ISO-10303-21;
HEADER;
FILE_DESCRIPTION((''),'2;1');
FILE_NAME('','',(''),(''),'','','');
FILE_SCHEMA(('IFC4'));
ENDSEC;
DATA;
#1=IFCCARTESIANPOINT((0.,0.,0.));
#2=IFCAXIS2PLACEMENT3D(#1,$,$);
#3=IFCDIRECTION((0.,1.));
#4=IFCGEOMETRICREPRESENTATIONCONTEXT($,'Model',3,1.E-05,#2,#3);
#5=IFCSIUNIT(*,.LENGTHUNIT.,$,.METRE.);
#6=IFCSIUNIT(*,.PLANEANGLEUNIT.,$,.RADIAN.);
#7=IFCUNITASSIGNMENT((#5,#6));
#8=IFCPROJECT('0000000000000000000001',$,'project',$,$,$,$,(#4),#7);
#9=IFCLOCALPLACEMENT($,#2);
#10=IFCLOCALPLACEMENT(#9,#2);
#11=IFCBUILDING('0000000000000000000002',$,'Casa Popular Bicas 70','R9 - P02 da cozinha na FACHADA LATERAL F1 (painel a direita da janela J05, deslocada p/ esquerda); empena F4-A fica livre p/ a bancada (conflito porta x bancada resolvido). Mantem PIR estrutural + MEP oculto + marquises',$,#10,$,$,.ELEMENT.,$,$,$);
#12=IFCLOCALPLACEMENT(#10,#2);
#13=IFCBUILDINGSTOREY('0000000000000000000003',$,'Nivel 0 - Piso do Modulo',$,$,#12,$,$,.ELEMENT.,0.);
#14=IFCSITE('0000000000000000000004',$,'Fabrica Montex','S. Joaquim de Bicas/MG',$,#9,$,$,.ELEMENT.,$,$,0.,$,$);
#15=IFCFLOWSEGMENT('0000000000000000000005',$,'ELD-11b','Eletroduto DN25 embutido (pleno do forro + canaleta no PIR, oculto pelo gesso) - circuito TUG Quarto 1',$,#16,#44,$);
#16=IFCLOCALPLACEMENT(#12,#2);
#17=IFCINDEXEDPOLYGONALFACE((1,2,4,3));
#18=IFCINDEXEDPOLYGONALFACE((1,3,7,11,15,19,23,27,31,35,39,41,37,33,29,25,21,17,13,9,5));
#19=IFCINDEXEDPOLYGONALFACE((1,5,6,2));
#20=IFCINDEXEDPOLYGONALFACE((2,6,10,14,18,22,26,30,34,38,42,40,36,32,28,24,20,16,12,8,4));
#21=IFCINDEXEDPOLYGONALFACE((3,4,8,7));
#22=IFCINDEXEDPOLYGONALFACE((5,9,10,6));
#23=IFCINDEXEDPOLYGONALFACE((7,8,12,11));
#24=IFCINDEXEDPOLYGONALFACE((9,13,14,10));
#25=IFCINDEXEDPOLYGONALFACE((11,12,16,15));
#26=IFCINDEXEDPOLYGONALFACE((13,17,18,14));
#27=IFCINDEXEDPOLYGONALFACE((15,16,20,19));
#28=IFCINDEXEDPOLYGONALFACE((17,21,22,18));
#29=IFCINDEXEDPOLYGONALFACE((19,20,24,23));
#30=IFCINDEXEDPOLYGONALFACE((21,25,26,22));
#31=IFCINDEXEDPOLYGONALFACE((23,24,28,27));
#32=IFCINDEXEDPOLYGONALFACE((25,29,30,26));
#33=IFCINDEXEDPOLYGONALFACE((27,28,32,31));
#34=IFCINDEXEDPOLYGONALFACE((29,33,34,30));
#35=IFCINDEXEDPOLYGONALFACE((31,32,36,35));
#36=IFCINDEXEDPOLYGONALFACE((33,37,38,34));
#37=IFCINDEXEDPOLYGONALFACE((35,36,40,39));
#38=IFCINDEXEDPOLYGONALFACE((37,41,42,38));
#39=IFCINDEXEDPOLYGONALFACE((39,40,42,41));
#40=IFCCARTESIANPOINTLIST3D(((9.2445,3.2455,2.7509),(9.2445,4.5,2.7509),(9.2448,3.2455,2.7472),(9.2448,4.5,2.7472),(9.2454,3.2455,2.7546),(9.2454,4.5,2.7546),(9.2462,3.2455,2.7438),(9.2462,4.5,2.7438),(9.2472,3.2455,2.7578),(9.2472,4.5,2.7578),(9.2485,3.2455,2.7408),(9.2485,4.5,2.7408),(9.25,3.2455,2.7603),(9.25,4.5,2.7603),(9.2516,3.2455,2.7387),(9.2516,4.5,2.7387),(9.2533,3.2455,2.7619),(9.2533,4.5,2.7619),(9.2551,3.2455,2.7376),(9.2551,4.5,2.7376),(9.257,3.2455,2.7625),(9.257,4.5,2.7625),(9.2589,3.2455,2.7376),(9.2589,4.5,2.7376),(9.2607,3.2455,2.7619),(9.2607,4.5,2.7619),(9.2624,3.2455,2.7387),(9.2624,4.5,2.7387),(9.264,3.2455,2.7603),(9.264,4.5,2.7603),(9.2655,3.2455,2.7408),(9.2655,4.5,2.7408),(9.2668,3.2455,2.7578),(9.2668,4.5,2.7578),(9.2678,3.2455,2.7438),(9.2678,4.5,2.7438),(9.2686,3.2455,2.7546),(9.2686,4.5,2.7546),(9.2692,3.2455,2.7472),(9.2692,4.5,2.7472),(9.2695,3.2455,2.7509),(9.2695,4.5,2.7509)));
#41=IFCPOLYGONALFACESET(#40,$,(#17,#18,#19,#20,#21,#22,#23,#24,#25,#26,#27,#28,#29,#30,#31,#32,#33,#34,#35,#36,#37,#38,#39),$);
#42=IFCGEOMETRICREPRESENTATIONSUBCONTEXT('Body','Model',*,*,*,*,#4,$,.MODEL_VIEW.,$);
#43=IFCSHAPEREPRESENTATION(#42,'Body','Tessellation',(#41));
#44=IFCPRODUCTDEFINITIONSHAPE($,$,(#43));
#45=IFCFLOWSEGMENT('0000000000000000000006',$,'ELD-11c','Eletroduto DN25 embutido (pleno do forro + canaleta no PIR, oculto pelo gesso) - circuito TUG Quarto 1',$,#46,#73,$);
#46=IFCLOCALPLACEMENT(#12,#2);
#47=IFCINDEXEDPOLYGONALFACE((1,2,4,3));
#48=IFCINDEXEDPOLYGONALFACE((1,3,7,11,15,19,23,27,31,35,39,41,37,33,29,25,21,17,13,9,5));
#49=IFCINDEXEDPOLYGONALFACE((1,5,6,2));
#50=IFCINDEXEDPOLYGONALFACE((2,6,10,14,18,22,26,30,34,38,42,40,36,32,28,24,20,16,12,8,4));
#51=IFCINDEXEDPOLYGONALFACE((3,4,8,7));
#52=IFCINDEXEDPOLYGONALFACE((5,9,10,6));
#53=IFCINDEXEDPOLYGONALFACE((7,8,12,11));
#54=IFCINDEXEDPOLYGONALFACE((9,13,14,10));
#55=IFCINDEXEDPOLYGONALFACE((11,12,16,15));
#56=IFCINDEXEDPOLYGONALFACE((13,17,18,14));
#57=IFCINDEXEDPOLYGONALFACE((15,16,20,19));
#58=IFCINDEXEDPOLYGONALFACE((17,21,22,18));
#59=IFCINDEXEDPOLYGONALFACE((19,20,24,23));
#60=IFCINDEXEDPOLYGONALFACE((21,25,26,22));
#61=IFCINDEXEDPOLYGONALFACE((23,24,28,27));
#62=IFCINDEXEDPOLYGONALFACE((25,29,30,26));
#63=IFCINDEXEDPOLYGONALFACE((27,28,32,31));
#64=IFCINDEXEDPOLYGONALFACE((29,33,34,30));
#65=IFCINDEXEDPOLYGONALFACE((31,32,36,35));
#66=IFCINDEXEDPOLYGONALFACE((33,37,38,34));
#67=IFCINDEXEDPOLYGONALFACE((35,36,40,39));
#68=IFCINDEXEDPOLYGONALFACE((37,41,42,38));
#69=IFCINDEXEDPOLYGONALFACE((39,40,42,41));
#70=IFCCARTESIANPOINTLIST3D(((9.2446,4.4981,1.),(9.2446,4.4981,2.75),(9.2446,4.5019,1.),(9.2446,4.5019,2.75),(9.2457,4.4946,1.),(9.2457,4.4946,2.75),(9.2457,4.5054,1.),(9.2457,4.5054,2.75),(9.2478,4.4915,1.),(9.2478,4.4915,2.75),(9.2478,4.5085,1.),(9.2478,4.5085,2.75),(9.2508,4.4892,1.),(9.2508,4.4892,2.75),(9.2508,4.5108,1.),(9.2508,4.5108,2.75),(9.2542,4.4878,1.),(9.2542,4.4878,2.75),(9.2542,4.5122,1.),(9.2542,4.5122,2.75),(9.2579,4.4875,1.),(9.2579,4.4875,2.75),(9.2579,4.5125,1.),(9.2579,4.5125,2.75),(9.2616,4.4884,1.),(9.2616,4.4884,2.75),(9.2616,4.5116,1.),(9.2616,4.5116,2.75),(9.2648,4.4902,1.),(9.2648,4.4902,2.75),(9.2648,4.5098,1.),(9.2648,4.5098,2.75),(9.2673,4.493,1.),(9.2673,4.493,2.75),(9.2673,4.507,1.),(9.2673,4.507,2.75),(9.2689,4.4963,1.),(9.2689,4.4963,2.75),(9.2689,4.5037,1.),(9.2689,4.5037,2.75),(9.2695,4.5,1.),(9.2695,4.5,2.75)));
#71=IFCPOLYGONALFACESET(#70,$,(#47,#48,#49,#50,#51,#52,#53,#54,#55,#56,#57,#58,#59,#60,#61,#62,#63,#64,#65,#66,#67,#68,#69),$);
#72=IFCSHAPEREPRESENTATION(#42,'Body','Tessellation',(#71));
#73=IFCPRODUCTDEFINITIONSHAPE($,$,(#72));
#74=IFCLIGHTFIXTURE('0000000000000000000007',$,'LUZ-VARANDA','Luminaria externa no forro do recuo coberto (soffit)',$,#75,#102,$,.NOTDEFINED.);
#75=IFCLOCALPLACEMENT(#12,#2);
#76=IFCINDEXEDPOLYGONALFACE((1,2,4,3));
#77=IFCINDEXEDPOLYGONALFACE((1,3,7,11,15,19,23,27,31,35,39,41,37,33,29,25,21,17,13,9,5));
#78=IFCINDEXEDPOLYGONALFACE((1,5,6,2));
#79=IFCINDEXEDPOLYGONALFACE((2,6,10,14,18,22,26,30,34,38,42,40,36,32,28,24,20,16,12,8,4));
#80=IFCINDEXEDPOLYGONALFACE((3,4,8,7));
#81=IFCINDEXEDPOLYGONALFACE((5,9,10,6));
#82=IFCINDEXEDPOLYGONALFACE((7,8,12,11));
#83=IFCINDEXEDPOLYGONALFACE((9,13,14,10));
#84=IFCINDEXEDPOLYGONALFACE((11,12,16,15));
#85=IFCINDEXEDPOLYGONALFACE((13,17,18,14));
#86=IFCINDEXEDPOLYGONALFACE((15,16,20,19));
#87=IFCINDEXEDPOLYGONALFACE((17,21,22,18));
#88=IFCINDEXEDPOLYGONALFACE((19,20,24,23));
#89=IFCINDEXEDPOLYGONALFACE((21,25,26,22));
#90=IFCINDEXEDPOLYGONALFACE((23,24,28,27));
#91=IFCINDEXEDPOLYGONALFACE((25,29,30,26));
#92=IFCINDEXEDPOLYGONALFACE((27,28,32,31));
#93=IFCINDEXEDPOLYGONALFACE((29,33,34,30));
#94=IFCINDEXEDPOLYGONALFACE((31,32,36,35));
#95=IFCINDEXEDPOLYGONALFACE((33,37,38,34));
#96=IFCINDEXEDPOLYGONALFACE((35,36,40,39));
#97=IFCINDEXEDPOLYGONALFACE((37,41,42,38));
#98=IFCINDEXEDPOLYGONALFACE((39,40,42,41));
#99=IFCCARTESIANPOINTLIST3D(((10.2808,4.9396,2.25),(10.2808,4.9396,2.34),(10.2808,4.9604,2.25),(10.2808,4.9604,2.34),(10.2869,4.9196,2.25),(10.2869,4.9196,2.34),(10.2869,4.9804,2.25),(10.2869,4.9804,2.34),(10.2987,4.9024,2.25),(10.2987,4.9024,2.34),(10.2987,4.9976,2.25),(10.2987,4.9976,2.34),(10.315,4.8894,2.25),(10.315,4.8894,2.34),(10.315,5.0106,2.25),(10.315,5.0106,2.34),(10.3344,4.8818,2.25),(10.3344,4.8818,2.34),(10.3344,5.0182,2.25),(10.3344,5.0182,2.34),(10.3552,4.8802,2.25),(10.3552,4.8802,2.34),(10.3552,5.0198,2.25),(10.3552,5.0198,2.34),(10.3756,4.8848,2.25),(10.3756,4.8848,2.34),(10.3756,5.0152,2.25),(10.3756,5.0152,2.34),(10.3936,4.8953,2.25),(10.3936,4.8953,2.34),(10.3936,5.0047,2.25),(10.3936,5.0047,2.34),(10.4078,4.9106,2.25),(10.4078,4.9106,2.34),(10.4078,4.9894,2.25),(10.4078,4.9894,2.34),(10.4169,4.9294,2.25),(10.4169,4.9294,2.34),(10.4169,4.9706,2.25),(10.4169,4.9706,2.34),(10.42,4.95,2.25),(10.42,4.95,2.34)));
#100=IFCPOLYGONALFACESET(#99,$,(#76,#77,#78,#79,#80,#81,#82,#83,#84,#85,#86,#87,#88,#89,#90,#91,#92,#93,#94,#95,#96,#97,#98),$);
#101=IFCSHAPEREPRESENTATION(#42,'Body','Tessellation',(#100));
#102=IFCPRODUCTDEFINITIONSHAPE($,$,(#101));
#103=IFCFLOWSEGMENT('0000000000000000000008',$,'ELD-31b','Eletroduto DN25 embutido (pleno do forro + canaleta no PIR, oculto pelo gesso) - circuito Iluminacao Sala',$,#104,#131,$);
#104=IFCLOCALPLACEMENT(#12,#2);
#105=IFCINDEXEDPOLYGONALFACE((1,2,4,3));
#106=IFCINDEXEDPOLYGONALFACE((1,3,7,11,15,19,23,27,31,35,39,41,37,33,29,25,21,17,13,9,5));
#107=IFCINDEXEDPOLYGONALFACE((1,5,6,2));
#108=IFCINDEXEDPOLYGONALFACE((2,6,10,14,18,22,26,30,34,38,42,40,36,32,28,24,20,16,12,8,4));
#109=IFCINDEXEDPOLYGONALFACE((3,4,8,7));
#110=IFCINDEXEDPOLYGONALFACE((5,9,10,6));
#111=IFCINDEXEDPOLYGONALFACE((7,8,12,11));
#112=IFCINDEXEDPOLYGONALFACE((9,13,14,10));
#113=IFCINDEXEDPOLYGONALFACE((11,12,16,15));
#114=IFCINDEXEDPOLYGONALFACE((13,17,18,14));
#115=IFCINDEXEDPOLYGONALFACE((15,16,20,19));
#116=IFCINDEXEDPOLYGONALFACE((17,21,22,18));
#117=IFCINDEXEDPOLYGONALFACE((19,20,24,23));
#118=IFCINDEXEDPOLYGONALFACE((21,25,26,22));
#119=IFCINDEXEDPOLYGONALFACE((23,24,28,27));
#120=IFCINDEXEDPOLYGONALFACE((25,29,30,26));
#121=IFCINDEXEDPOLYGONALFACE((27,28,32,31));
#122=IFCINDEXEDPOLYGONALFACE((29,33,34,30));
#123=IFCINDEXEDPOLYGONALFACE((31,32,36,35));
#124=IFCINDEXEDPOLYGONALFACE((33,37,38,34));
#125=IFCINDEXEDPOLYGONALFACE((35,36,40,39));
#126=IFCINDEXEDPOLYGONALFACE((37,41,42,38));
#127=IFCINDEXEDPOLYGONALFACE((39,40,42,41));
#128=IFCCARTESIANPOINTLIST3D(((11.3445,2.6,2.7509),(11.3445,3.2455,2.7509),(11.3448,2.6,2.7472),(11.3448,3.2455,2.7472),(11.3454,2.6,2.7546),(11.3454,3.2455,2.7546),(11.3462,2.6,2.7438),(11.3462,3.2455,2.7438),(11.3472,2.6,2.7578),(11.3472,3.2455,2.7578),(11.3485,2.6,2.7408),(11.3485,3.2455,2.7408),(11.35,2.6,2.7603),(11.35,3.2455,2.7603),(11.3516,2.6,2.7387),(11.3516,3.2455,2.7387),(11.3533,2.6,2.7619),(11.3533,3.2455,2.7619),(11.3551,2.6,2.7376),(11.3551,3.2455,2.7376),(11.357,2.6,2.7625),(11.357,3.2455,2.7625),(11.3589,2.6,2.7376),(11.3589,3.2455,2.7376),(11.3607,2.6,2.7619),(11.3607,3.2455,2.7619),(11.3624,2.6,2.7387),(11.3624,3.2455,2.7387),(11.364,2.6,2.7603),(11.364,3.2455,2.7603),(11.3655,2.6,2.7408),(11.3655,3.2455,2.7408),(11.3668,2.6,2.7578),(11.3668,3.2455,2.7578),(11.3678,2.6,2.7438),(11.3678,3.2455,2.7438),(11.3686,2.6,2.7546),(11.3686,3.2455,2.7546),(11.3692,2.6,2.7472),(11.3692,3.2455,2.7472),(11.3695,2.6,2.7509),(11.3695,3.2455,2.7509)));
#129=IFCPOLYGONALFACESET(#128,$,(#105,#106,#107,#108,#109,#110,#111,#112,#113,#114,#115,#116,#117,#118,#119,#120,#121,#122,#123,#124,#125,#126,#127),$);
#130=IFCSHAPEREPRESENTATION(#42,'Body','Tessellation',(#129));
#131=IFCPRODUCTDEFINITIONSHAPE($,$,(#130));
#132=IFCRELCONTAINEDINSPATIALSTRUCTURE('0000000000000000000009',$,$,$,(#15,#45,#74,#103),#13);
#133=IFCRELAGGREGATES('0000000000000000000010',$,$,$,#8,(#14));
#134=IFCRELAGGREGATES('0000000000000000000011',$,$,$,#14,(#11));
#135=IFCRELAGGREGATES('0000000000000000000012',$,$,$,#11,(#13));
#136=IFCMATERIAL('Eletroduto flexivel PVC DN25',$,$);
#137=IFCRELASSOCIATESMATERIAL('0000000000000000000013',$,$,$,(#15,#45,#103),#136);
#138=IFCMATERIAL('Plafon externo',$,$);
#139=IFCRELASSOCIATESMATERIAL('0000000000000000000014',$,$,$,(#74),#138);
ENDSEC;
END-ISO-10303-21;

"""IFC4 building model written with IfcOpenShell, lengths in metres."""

from ifc_helpers import new_model, si_unit, direction, frame, origin, origin_2d, place, context, subcontext, project, spatial, circle, extrude, material, element, save


model = new_model("IFC4")

# Units and contexts
model_context = context("Model", 3, precision=1e-05, world=origin(), true_north=direction((0.0, 1.0)))
body_context = subcontext(model_context, "Body", "Model", "MODEL_VIEW")
ifc_project = project(units=[si_unit("LENGTHUNIT", "METRE"), si_unit("PLANEANGLEUNIT", "RADIAN")], contexts=[model_context])

# Site, building, storey
site_placement = place(None, origin())
site = spatial("IfcSite", under=ifc_project, at=site_placement, Name="Fabrica Montex", Description="S. Joaquim de Bicas/MG", CompositionType="ELEMENT", RefElevation=0.0)
building_placement = place(site_placement, origin())
building = spatial("IfcBuilding", under=site, at=building_placement, Name="Casa Popular Bicas 70", Description="R9 - P02 da cozinha na FACHADA LATERAL F1 (painel a direita da janela J05, deslocada p/ esquerda); empena F4-A fica livre p/ a bancada (conflito porta x bancada resolvido). Mantem PIR estrutural + MEP oculto + marquises", CompositionType="ELEMENT")
storey_placement = place(building_placement, origin())
storey = spatial("IfcBuildingStorey", under=building, at=storey_placement, Name="Nivel 0 - Piso do Modulo", CompositionType="ELEMENT", Elevation=0.0)

# Flow segments
ifc_material_1 = material(Name="Eletroduto flexivel PVC DN25")
flow_segment_1_placement = place(storey_placement, frame((9.257, 3.2455, 2.75), z_axis=(0.0, 1.0, 0.0), x_axis=(0.0, 0.0, 1.0)))
element("IfcFlowSegment", 1, at=flow_segment_1_placement, inside=storey, material=ifc_material_1, Name="ELD-11b", Description="Eletroduto DN25 embutido (pleno do forro + canaleta no PIR, oculto pelo gesso) - circuito TUG Quarto 1", context=body_context, shape_type="SweptSolid", body=[
    extrude(circle(Radius=0.0125, at=origin_2d()), origin(), (0.0, 0.0, 1.0), 1.2545),
])
flow_segment_2_placement = place(storey_placement, frame((9.257, 4.5, 2.75), z_axis=(0.0, 0.0, -1.0), x_axis=(1.0, 0.0, 0.0)))
element("IfcFlowSegment", 2, at=flow_segment_2_placement, inside=storey, material=ifc_material_1, Name="ELD-11c", Description="Eletroduto DN25 embutido (pleno do forro + canaleta no PIR, oculto pelo gesso) - circuito TUG Quarto 1", context=body_context, shape_type="SweptSolid", body=[
    extrude(circle(Radius=0.0125, at=origin_2d()), origin(), (0.0, 0.0, 1.0), 1.75),
])

# Light fixture
ifc_material_2 = material(Name="Plafon externo")
light_fixture_placement = place(storey_placement, frame((10.35, 4.95, 2.25)))
element("IfcLightFixture", 3, at=light_fixture_placement, inside=storey, material=ifc_material_2, Name="LUZ-VARANDA", Description="Luminaria externa no forro do recuo coberto (soffit)", PredefinedType="NOTDEFINED", context=body_context, shape_type="SweptSolid", body=[
    extrude(circle(Radius=0.07, at=origin_2d()), origin(), (0.0, 0.0, 1.0), 0.09),
])

# Flow segment
flow_segment_3_placement = place(storey_placement, frame((11.357, 3.2455, 2.75), z_axis=(0.0, -1.0, 0.0), x_axis=(0.0, 0.0, 1.0)))
element("IfcFlowSegment", 4, at=flow_segment_3_placement, inside=storey, material=ifc_material_1, Name="ELD-31b", Description="Eletroduto DN25 embutido (pleno do forro + canaleta no PIR, oculto pelo gesso) - circuito Iluminacao Sala", context=body_context, shape_type="SweptSolid", body=[
    extrude(circle(Radius=0.0125, at=origin_2d()), origin(), (0.0, 0.0, 1.0), 0.6455),
])

save(model, "model.ifc")
